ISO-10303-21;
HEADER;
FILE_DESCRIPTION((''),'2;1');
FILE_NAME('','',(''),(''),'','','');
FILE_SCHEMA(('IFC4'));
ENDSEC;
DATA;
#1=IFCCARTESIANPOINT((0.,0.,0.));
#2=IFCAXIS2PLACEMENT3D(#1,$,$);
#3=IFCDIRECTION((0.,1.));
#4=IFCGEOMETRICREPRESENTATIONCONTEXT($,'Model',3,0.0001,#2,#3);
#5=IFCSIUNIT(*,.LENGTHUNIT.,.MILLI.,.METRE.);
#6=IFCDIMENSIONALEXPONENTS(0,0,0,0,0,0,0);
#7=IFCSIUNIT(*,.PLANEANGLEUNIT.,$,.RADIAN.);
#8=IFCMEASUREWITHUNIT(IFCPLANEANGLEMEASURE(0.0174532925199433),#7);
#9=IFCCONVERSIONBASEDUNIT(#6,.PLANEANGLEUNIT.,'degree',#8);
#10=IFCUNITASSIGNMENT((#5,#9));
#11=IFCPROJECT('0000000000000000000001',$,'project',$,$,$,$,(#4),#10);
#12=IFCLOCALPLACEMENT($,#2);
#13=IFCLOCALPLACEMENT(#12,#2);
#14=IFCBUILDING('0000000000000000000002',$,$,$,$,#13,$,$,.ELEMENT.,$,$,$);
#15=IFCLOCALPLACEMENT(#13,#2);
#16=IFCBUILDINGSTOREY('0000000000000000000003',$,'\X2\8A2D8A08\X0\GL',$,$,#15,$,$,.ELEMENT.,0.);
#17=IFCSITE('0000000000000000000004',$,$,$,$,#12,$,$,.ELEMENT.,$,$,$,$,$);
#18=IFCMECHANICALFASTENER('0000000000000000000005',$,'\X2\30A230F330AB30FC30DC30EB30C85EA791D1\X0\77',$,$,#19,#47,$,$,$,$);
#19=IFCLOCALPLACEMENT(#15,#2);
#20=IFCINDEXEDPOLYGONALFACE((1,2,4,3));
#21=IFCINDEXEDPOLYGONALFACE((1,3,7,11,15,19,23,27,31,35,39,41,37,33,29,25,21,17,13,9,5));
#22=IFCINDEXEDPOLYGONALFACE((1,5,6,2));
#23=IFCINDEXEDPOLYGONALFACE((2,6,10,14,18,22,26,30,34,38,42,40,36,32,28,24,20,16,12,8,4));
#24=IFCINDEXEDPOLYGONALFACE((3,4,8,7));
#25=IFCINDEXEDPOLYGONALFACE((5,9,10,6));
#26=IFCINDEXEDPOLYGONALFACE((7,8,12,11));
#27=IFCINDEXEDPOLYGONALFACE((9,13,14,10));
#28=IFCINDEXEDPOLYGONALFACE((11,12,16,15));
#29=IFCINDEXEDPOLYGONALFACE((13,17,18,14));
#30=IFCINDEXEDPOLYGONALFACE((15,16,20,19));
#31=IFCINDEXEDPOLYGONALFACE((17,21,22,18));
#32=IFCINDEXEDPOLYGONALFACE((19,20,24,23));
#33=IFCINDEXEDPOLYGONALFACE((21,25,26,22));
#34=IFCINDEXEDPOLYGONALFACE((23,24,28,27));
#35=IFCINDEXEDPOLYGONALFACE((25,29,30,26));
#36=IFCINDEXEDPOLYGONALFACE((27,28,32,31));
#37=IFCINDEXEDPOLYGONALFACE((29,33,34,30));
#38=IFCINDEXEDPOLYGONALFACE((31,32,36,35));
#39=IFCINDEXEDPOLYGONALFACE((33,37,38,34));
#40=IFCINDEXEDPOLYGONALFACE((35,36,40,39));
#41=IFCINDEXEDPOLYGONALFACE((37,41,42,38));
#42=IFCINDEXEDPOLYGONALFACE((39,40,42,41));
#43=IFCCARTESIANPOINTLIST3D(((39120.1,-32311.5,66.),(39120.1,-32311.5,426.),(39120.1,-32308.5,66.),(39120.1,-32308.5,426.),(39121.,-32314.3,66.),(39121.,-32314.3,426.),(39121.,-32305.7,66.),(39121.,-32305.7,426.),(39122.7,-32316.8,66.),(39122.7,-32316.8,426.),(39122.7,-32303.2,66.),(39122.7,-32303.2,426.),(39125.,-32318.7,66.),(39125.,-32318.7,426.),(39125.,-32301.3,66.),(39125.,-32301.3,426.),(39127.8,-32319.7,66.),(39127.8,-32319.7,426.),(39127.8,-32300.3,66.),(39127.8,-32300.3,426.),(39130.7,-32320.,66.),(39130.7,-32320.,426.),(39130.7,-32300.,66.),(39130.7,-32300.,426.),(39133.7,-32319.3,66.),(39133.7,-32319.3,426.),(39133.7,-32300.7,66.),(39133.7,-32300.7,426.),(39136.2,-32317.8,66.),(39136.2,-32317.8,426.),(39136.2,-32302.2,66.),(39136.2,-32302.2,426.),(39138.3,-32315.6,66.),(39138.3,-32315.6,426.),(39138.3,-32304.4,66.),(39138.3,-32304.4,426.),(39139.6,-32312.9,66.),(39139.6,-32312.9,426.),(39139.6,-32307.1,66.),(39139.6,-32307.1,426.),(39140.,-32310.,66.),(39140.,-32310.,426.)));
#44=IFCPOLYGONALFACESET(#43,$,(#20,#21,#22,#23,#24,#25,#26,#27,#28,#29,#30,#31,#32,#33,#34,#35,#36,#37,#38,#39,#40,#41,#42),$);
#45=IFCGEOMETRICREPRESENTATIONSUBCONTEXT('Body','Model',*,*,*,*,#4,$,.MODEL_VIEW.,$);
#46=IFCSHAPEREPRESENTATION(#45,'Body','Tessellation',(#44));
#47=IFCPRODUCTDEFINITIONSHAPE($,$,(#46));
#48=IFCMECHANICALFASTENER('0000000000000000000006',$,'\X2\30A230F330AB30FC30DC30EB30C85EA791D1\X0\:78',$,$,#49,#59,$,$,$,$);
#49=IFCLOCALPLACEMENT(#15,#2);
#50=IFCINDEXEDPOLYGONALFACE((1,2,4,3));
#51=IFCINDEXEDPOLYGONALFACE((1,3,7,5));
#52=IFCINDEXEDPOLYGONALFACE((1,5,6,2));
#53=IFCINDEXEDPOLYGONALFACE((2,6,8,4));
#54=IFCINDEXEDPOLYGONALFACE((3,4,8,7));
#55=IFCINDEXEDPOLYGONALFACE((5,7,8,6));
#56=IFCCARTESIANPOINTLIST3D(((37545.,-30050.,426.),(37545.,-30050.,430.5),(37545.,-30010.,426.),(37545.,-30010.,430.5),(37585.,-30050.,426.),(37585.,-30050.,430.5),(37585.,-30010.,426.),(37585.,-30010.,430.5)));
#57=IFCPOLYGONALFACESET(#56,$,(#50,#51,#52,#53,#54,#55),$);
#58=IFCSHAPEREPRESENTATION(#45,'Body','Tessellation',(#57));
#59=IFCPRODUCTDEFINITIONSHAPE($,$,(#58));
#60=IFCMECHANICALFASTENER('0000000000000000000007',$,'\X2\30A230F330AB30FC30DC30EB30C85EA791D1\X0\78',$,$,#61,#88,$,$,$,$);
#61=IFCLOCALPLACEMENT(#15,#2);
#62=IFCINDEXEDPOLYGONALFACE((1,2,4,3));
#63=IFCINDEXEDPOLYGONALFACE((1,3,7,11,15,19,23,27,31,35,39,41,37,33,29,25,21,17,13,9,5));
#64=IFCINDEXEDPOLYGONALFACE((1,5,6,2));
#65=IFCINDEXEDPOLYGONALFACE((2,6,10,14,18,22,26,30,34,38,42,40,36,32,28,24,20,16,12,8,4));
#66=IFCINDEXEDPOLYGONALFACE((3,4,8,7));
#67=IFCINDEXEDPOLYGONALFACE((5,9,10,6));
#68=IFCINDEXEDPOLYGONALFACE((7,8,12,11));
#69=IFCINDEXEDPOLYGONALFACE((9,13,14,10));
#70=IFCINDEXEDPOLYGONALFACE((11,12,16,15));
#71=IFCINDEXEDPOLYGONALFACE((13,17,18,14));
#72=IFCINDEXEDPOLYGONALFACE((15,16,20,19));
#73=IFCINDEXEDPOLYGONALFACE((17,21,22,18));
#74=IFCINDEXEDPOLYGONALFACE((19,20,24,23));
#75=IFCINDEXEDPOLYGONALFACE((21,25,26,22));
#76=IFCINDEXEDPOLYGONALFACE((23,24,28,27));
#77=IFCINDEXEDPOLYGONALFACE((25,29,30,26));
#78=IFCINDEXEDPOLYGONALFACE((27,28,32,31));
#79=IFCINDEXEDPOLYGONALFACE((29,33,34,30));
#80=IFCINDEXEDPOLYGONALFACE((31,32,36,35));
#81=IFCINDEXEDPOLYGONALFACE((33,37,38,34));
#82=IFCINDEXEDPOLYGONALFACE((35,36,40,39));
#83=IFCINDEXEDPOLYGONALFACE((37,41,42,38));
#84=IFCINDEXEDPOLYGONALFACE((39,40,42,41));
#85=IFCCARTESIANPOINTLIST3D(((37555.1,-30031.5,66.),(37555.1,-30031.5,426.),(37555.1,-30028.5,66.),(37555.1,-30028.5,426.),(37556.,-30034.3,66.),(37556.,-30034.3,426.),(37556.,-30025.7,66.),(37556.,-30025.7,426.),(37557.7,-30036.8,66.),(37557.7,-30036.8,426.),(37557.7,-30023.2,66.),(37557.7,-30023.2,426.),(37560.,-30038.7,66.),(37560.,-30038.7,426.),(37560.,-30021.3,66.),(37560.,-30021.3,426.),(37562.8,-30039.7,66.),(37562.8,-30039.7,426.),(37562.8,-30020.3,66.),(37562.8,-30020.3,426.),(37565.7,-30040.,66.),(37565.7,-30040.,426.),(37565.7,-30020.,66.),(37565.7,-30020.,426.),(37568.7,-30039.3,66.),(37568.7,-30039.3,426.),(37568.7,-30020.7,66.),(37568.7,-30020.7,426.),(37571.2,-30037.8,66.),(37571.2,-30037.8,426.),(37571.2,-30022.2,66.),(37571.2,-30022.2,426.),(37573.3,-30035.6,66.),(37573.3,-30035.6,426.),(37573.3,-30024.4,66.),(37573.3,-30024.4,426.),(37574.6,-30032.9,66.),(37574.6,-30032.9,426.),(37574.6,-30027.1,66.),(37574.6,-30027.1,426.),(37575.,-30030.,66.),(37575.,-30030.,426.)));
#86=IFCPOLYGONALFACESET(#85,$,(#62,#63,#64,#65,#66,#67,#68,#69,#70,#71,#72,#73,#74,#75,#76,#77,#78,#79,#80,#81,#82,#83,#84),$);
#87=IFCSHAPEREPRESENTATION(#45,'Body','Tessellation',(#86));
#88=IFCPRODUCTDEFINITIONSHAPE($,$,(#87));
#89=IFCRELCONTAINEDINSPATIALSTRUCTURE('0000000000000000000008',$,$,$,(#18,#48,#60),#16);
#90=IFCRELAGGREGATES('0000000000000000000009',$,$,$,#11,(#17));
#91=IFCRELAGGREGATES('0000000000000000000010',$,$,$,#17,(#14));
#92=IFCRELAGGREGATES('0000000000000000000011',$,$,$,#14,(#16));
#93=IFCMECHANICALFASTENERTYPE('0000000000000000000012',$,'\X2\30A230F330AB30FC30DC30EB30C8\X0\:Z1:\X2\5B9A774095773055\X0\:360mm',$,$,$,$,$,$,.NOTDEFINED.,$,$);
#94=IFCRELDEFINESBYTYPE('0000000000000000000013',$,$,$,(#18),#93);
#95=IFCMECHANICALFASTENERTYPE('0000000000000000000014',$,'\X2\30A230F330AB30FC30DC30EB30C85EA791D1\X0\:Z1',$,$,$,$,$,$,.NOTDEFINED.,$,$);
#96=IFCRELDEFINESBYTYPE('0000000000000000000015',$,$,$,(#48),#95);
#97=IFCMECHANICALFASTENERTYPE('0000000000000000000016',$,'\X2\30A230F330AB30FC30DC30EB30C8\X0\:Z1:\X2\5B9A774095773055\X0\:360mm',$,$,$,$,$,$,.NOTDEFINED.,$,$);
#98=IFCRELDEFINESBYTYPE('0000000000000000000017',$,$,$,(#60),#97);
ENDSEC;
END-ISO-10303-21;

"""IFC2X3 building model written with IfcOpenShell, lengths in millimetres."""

from ifc_helpers import new_model, entity, si_unit, converted_unit, direction, frame, origin, origin_with_axes, origin_2d, place, context, subcontext, project, spatial, rectangle, circle, extrude, type_object, element, save


model = new_model("IFC2X3")

# Units and contexts
model_context = context("Model", 3, precision=0.0001, world=origin(), true_north=direction((0.0, 1.0)))
body_context = subcontext(model_context, "Body", "Model", "MODEL_VIEW")
ifc_project = project(units=[si_unit("LENGTHUNIT", "METRE", prefix="MILLI"), converted_unit("PLANEANGLEUNIT", "degree", entity("IfcPlaneAngleMeasure", 0.0174532925199433), si_unit("PLANEANGLEUNIT", "RADIAN"), dimensions=[0, 0, 0, 0, 0, 0, 0])], contexts=[model_context])

# Site, building, storey
site_placement = place(None, origin())
site = spatial("IfcSite", under=ifc_project, at=site_placement, CompositionType="ELEMENT")
building_placement = place(site_placement, origin())
building = spatial("IfcBuilding", under=site, at=building_placement, CompositionType="ELEMENT")
storey_placement = place(building_placement, origin())
storey = spatial("IfcBuildingStorey", under=building, at=storey_placement, Name="設計GL", CompositionType="ELEMENT", Elevation=0.0)

# Mechanical fasteners
mechanical_fastener_type_1 = type_object("IfcMechanicalFastenerType", Name="アンカーボルト:Z1:定着長さ:360mm")
mechanical_fastener_1_placement = place(storey_placement, frame((39130.0, -32310.0, 66.0)))
element("IfcMechanicalFastener", 1, at=mechanical_fastener_1_placement, inside=storey, type_object=mechanical_fastener_type_1, Name="アンカーボルト座金77", context=body_context, shape_type="SweptSolid", body=[
    extrude(circle(Radius=10.0, at=origin_2d()), origin_with_axes(), (0.0, 0.0, 1.0), 360.0),
])
mechanical_fastener_type_2 = type_object("IfcMechanicalFastenerType", Name="アンカーボルト座金:Z1")
mechanical_fastener_2_placement = place(storey_placement, frame((37565.0, -30030.0, 426.0)))
element("IfcMechanicalFastener", 2, at=mechanical_fastener_2_placement, inside=storey, type_object=mechanical_fastener_type_2, Name="アンカーボルト座金:78", context=body_context, shape_type="SweptSolid", body=[
    extrude(rectangle(XDim=40.0, YDim=40.0, at=origin_2d()), origin_with_axes(), (0.0, 0.0, 1.0), 4.5),
])
mechanical_fastener_type_3 = type_object("IfcMechanicalFastenerType", Name="アンカーボルト:Z1:定着長さ:360mm")
mechanical_fastener_3_placement = place(storey_placement, frame((37565.0, -30030.0, 66.0)))
element("IfcMechanicalFastener", 3, at=mechanical_fastener_3_placement, inside=storey, type_object=mechanical_fastener_type_3, Name="アンカーボルト座金78", context=body_context, shape_type="SweptSolid", body=[
    extrude(circle(Radius=10.0, at=origin_2d()), origin_with_axes(), (0.0, 0.0, 1.0), 360.0),
])

save(model, "model.ifc")
